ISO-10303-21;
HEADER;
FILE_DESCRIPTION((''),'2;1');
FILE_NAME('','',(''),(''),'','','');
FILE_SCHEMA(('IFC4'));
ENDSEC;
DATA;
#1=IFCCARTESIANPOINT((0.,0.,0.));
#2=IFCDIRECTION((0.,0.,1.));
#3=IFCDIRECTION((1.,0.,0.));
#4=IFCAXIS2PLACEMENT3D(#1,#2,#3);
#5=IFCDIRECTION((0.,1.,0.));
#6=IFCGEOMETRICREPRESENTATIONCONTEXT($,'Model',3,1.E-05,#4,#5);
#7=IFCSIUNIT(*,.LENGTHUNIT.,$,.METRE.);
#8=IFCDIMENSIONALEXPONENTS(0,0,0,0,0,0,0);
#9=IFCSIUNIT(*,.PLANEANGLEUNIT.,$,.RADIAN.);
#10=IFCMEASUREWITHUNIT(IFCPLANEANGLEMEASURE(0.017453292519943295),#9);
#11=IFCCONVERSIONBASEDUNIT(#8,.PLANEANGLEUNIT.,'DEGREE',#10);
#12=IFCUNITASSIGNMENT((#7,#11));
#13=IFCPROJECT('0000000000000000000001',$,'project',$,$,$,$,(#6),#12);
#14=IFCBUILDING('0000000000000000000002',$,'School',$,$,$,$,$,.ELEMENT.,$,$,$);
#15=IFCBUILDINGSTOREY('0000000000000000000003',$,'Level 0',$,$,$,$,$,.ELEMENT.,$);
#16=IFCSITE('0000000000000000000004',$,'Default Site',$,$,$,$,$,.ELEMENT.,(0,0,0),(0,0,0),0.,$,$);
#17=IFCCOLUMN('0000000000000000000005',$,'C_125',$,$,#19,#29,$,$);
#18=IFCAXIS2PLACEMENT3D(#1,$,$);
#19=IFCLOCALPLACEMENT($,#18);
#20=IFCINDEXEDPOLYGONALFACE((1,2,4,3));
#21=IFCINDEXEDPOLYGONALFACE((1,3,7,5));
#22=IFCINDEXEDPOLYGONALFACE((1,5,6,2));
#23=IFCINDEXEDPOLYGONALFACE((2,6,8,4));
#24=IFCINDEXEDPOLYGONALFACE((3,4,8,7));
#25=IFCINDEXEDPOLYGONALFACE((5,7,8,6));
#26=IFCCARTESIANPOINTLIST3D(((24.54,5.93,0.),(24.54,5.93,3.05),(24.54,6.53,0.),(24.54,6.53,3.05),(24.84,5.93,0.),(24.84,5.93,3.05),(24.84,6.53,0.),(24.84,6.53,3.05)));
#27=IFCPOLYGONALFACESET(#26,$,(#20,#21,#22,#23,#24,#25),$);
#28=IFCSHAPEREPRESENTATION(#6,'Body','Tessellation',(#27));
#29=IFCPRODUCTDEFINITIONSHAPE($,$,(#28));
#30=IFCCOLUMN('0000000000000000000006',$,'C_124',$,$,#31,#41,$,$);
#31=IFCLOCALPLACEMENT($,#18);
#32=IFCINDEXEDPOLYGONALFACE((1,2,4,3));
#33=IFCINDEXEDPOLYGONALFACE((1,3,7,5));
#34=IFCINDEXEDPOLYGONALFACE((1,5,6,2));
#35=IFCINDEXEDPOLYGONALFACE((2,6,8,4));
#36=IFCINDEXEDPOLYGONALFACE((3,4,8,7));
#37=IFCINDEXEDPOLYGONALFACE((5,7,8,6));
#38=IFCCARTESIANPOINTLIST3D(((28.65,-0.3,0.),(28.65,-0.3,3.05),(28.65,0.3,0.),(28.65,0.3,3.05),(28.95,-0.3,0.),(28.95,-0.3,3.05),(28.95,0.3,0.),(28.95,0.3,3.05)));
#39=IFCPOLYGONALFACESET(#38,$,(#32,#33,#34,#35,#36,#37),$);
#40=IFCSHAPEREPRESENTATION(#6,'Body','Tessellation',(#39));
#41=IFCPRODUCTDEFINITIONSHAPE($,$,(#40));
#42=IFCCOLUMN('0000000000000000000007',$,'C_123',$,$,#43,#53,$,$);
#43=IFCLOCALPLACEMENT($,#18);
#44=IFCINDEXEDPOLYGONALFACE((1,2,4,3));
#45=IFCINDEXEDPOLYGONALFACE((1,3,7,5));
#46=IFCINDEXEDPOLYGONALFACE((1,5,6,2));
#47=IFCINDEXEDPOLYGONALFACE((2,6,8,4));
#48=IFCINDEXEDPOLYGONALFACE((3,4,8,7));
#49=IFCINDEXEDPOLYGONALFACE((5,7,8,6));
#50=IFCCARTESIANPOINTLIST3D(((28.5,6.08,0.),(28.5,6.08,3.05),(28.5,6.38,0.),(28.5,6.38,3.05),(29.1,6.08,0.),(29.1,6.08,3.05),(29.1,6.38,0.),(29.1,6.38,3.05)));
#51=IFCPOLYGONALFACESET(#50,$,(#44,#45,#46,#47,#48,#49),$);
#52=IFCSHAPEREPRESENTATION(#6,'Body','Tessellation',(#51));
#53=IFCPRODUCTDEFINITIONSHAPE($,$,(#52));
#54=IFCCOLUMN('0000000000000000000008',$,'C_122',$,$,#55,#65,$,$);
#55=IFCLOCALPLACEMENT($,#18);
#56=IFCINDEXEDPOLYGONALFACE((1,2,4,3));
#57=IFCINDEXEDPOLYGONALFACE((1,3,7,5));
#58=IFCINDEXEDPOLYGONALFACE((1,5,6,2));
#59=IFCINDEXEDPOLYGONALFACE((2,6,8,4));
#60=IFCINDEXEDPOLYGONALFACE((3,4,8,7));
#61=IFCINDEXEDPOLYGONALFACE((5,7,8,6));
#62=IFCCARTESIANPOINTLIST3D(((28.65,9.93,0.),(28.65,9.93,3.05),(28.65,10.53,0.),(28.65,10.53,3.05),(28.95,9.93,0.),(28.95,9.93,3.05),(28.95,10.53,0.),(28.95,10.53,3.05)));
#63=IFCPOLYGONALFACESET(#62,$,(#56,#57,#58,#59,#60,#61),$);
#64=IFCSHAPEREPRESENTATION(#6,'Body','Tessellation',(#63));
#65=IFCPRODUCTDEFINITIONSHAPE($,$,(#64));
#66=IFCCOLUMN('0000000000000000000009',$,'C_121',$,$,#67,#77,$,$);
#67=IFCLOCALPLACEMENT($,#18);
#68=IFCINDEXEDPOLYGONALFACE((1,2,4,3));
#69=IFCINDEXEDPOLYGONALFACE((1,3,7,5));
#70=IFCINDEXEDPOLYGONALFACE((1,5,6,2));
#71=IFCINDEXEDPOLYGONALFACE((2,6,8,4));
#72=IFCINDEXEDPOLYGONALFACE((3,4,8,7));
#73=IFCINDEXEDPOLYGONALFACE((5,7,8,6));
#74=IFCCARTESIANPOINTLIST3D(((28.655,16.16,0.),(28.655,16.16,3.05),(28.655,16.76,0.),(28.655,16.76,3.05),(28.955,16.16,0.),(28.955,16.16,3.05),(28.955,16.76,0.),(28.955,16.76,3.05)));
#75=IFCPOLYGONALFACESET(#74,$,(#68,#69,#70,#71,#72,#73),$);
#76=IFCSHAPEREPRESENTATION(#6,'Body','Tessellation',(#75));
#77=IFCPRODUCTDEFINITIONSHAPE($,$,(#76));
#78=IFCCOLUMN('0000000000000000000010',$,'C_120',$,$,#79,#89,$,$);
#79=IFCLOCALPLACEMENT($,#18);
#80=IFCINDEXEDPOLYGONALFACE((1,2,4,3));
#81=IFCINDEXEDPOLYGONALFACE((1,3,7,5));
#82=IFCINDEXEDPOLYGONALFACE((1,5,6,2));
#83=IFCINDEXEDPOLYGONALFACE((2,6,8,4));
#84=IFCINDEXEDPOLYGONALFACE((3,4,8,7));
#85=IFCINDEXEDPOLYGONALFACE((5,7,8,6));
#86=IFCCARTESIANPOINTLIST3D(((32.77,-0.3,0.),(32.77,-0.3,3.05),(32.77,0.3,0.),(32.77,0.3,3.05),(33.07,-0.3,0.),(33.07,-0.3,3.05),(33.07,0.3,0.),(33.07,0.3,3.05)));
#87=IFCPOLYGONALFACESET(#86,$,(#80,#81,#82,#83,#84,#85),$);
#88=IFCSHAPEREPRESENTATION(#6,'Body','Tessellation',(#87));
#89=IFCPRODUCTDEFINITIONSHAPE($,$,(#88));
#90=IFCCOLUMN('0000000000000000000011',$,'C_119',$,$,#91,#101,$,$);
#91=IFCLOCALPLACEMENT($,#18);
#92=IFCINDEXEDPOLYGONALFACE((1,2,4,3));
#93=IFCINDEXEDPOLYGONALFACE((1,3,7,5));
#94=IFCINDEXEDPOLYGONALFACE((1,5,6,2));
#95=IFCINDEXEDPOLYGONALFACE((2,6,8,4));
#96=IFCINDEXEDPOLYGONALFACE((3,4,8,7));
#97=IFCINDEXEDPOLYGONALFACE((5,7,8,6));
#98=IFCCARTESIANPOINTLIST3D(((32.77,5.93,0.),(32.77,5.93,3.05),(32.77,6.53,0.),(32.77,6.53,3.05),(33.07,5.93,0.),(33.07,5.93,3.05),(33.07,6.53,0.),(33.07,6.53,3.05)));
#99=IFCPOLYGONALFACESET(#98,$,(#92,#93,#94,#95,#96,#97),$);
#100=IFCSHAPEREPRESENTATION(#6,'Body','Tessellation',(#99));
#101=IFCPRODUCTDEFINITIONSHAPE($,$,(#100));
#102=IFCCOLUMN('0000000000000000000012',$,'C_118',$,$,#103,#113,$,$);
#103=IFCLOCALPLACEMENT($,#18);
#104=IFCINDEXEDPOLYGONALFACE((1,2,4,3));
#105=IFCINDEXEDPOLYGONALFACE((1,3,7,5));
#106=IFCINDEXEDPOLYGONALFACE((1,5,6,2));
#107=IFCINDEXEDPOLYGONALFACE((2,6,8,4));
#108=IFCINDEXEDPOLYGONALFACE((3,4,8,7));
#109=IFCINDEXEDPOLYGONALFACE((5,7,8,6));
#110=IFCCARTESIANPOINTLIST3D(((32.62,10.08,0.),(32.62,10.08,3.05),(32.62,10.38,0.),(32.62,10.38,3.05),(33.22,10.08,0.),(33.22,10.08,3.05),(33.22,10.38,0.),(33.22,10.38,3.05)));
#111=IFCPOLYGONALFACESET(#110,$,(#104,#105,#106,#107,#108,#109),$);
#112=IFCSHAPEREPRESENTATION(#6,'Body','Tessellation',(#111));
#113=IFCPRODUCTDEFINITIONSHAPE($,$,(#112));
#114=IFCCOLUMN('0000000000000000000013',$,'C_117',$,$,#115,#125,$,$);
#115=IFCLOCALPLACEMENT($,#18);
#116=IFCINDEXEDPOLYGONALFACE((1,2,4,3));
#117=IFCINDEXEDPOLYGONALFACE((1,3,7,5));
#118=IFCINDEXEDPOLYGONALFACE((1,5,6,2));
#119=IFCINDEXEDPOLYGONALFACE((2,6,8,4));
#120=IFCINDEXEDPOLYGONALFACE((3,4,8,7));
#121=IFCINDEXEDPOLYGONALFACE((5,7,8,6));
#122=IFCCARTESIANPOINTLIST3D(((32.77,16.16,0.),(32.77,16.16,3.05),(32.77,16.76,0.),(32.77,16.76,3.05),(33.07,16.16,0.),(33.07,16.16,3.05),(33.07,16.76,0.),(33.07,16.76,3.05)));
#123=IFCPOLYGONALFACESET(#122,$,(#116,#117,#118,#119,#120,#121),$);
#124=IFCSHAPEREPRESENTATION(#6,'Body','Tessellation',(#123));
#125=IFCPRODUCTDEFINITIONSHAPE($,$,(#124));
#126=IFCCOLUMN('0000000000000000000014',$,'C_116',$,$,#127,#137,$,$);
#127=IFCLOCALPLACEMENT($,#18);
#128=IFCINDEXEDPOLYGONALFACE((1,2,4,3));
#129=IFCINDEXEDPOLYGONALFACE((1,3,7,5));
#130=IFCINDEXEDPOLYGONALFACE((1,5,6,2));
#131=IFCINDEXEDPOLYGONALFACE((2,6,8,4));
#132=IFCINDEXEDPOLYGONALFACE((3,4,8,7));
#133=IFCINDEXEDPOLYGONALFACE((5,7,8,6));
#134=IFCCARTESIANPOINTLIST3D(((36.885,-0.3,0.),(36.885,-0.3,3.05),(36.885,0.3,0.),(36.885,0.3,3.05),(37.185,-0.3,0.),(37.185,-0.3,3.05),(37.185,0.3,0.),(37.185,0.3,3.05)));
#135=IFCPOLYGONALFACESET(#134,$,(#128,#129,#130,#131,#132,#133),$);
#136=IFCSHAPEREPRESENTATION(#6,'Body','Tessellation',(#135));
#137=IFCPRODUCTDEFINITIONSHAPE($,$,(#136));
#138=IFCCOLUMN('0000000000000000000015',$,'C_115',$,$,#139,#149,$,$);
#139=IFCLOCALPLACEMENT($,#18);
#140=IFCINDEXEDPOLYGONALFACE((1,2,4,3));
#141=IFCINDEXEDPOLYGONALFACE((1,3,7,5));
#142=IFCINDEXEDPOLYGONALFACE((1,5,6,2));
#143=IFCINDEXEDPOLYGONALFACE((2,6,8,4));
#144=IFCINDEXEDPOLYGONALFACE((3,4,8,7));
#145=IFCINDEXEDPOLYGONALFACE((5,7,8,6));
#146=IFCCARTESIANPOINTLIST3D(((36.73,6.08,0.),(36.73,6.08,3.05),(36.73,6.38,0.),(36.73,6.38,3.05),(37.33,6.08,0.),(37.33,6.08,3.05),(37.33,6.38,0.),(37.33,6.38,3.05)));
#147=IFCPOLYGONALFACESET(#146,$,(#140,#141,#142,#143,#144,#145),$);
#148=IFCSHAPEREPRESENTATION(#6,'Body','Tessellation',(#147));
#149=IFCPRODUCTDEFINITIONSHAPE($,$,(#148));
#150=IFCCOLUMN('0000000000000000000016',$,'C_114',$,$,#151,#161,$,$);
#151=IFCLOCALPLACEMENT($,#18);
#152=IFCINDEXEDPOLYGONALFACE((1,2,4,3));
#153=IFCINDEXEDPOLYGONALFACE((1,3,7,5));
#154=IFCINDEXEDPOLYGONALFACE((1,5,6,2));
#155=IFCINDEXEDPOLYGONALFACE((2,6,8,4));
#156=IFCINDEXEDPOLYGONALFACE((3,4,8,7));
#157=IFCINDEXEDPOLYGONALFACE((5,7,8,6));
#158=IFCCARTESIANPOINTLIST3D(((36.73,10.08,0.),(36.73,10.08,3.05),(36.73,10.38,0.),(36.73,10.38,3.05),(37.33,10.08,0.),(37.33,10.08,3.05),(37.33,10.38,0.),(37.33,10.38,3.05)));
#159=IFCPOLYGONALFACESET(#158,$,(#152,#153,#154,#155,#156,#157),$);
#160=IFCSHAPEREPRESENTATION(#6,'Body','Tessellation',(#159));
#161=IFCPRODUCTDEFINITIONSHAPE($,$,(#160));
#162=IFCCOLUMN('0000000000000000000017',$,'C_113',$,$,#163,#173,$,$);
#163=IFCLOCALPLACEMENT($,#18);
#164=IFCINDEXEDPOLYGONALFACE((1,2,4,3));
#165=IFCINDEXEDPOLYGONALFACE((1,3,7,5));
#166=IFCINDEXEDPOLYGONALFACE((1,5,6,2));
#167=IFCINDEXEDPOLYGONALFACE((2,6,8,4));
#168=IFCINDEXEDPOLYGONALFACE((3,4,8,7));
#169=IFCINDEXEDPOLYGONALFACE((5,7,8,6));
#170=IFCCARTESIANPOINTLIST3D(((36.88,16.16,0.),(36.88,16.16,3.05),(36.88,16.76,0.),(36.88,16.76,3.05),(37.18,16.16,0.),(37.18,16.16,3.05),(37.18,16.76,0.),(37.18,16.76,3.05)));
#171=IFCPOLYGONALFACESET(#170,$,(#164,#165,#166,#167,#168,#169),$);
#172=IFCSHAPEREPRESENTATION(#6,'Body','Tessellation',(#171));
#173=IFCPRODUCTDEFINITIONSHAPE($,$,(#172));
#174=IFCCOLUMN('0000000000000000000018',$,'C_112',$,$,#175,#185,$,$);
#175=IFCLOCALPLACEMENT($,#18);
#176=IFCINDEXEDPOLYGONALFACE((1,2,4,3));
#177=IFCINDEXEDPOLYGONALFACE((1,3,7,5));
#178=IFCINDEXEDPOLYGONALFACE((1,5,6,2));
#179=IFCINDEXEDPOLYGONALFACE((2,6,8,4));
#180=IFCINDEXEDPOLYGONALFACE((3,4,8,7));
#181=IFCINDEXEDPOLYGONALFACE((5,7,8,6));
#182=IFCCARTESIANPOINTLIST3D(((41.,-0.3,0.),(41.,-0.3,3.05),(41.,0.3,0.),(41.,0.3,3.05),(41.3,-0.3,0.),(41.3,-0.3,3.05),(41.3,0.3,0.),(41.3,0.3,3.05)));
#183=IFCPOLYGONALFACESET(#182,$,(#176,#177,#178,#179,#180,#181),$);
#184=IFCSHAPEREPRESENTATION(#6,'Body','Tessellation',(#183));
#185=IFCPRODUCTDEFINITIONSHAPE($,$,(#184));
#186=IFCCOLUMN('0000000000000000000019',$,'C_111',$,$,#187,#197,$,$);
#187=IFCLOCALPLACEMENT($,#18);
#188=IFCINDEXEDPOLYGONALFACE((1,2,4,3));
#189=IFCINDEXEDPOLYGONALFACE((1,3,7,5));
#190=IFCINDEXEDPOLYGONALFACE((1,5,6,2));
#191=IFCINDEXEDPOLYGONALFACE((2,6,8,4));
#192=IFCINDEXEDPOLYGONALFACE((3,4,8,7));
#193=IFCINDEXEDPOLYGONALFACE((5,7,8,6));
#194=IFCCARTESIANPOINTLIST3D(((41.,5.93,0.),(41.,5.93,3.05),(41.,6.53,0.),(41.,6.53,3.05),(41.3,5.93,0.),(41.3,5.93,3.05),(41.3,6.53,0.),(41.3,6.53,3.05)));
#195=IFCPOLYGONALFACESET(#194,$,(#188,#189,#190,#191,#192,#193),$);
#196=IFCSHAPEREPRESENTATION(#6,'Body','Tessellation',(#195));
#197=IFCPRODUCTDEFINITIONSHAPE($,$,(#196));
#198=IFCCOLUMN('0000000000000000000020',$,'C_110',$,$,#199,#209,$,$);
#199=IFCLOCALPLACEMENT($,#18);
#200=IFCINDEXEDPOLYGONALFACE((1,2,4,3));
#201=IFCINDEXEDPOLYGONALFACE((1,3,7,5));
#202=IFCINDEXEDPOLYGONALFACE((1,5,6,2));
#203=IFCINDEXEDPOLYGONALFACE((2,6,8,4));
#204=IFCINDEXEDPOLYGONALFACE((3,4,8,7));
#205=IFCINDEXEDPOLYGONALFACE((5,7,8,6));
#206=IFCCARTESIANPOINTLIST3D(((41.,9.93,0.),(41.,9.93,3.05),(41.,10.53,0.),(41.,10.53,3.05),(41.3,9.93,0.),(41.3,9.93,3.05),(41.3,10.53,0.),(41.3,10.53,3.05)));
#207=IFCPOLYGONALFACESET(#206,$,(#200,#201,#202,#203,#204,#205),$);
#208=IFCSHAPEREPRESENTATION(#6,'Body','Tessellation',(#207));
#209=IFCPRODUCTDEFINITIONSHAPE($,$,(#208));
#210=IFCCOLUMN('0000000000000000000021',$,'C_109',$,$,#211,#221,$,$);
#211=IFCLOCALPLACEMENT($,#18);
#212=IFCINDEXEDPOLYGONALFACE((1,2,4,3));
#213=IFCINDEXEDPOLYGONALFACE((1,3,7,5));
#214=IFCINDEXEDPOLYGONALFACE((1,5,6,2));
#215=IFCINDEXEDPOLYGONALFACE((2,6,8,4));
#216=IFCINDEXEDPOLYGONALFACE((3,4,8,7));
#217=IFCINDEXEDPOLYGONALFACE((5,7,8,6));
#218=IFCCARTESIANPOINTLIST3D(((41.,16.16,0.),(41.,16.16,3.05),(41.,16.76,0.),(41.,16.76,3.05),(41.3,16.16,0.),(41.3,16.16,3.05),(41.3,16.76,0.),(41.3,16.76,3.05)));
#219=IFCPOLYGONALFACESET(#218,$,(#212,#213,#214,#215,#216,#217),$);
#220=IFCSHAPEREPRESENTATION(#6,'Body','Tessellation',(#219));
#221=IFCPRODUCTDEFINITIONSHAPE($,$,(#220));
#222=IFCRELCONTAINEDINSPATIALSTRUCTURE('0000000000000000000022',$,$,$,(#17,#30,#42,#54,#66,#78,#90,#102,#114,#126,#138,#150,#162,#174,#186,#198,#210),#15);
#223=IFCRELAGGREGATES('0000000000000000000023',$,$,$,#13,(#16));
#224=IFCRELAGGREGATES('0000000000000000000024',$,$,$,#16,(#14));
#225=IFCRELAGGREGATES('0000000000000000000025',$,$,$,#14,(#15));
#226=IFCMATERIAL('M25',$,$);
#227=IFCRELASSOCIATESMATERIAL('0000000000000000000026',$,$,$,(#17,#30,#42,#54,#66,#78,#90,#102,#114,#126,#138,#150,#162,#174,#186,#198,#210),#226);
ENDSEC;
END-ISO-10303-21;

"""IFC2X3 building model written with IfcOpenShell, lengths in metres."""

from ifc_helpers import new_model, entity, si_unit, converted_unit, direction, frame, frame_2d, origin_with_axes, place, context, project, spatial, rectangle, extrude, material, element, save


model = new_model("IFC2X3")

# Units and contexts
model_context = context("Model", 3, precision=1e-05, world=origin_with_axes(), true_north=direction((0.0, 1.0, 0.0)))
ifc_project = project(units=[si_unit("LENGTHUNIT", "METRE"), converted_unit("PLANEANGLEUNIT", "DEGREE", entity("IfcPlaneAngleMeasure", 0.017453292519943295), si_unit("PLANEANGLEUNIT", "RADIAN"), dimensions=[0, 0, 0, 0, 0, 0, 0])], contexts=[model_context])

# Site, building, storey
site = spatial("IfcSite", under=ifc_project, Name="Default Site", CompositionType="ELEMENT", RefLatitude=(0, 0, 0), RefLongitude=(0, 0, 0), RefElevation=0.0)
building = spatial("IfcBuilding", under=site, Name="School", CompositionType="ELEMENT")
storey = spatial("IfcBuildingStorey", under=building, Name="Level 0", CompositionType="ELEMENT")

# Columns
ifc_material = material(Name="M25")
placement = place(None, origin_with_axes())
element("IfcColumn", 1, at=placement, inside=storey, material=ifc_material, Name="C_125", context=model_context, shape_type="SweptSolid", body=[
    extrude(rectangle(XDim=0.3, YDim=0.6, at=frame_2d((0.0, 0.0), x_axis=(1.0, 0.0, 0.0))), frame((24.69, 6.23, 0.0), z_axis=(0.0, 0.0, 1.0), x_axis=(1.0, 0.0, 0.0)), (0.0, 0.0, 1.0), 3.05),
])
element("IfcColumn", 2, at=placement, inside=storey, material=ifc_material, Name="C_124", context=model_context, shape_type="SweptSolid", body=[
    extrude(rectangle(XDim=0.3, YDim=0.6, at=frame_2d((0.0, 0.0), x_axis=(1.0, 0.0, 0.0))), frame((28.8, 0.0, 0.0), z_axis=(0.0, 0.0, 1.0), x_axis=(1.0, 0.0, 0.0)), (0.0, 0.0, 1.0), 3.05),
])
element("IfcColumn", 3, at=placement, inside=storey, material=ifc_material, Name="C_123", context=model_context, shape_type="SweptSolid", body=[
    extrude(rectangle(XDim=0.6, YDim=0.3, at=frame_2d((0.0, 0.0), x_axis=(1.0, 0.0, 0.0))), frame((28.8, 6.23, 0.0), z_axis=(0.0, 0.0, 1.0), x_axis=(1.0, 0.0, 0.0)), (0.0, 0.0, 1.0), 3.05),
])
element("IfcColumn", 4, at=placement, inside=storey, material=ifc_material, Name="C_122", context=model_context, shape_type="SweptSolid", body=[
    extrude(rectangle(XDim=0.3, YDim=0.6, at=frame_2d((0.0, 0.0), x_axis=(1.0, 0.0, 0.0))), frame((28.8, 10.23, 0.0), z_axis=(0.0, 0.0, 1.0), x_axis=(1.0, 0.0, 0.0)), (0.0, 0.0, 1.0), 3.05),
])
element("IfcColumn", 5, at=placement, inside=storey, material=ifc_material, Name="C_121", context=model_context, shape_type="SweptSolid", body=[
    extrude(rectangle(XDim=0.3, YDim=0.6, at=frame_2d((0.0, 0.0), x_axis=(1.0, 0.0, 0.0))), frame((28.805, 16.46, 0.0), z_axis=(0.0, 0.0, 1.0), x_axis=(1.0, 0.0, 0.0)), (0.0, 0.0, 1.0), 3.05),
])
element("IfcColumn", 6, at=placement, inside=storey, material=ifc_material, Name="C_120", context=model_context, shape_type="SweptSolid", body=[
    extrude(rectangle(XDim=0.3, YDim=0.6, at=frame_2d((0.0, 0.0), x_axis=(1.0, 0.0, 0.0))), frame((32.92, 0.0, 0.0), z_axis=(0.0, 0.0, 1.0), x_axis=(1.0, 0.0, 0.0)), (0.0, 0.0, 1.0), 3.05),
])
element("IfcColumn", 7, at=placement, inside=storey, material=ifc_material, Name="C_119", context=model_context, shape_type="SweptSolid", body=[
    extrude(rectangle(XDim=0.3, YDim=0.6, at=frame_2d((0.0, 0.0), x_axis=(1.0, 0.0, 0.0))), frame((32.92, 6.23, 0.0), z_axis=(0.0, 0.0, 1.0), x_axis=(1.0, 0.0, 0.0)), (0.0, 0.0, 1.0), 3.05),
])
element("IfcColumn", 8, at=placement, inside=storey, material=ifc_material, Name="C_118", context=model_context, shape_type="SweptSolid", body=[
    extrude(rectangle(XDim=0.6, YDim=0.3, at=frame_2d((0.0, 0.0), x_axis=(1.0, 0.0, 0.0))), frame((32.92, 10.23, 0.0), z_axis=(0.0, 0.0, 1.0), x_axis=(1.0, 0.0, 0.0)), (0.0, 0.0, 1.0), 3.05),
])
element("IfcColumn", 9, at=placement, inside=storey, material=ifc_material, Name="C_117", context=model_context, shape_type="SweptSolid", body=[
    extrude(rectangle(XDim=0.3, YDim=0.6, at=frame_2d((0.0, 0.0), x_axis=(1.0, 0.0, 0.0))), frame((32.92, 16.46, 0.0), z_axis=(0.0, 0.0, 1.0), x_axis=(1.0, 0.0, 0.0)), (0.0, 0.0, 1.0), 3.05),
])
element("IfcColumn", 10, at=placement, inside=storey, material=ifc_material, Name="C_116", context=model_context, shape_type="SweptSolid", body=[
    extrude(rectangle(XDim=0.3, YDim=0.6, at=frame_2d((0.0, 0.0), x_axis=(1.0, 0.0, 0.0))), frame((37.035, 0.0, 0.0), z_axis=(0.0, 0.0, 1.0), x_axis=(1.0, 0.0, 0.0)), (0.0, 0.0, 1.0), 3.05),
])
element("IfcColumn", 11, at=placement, inside=storey, material=ifc_material, Name="C_115", context=model_context, shape_type="SweptSolid", body=[
    extrude(rectangle(XDim=0.6, YDim=0.3, at=frame_2d((0.0, 0.0), x_axis=(1.0, 0.0, 0.0))), frame((37.03, 6.23, 0.0), z_axis=(0.0, 0.0, 1.0), x_axis=(1.0, 0.0, 0.0)), (0.0, 0.0, 1.0), 3.05),
])
element("IfcColumn", 12, at=placement, inside=storey, material=ifc_material, Name="C_114", context=model_context, shape_type="SweptSolid", body=[
    extrude(rectangle(XDim=0.6, YDim=0.3, at=frame_2d((0.0, 0.0), x_axis=(1.0, 0.0, 0.0))), frame((37.03, 10.23, 0.0), z_axis=(0.0, 0.0, 1.0), x_axis=(1.0, 0.0, 0.0)), (0.0, 0.0, 1.0), 3.05),
])
element("IfcColumn", 13, at=placement, inside=storey, material=ifc_material, Name="C_113", context=model_context, shape_type="SweptSolid", body=[
    extrude(rectangle(XDim=0.3, YDim=0.6, at=frame_2d((0.0, 0.0), x_axis=(1.0, 0.0, 0.0))), frame((37.03, 16.46, 0.0), z_axis=(0.0, 0.0, 1.0), x_axis=(1.0, 0.0, 0.0)), (0.0, 0.0, 1.0), 3.05),
])
element("IfcColumn", 14, at=placement, inside=storey, material=ifc_material, Name="C_112", context=model_context, shape_type="SweptSolid", body=[
    extrude(rectangle(XDim=0.3, YDim=0.6, at=frame_2d((0.0, 0.0), x_axis=(1.0, 0.0, 0.0))), frame((41.15, 0.0, 0.0), z_axis=(0.0, 0.0, 1.0), x_axis=(1.0, 0.0, 0.0)), (0.0, 0.0, 1.0), 3.05),
])
element("IfcColumn", 15, at=placement, inside=storey, material=ifc_material, Name="C_111", context=model_context, shape_type="SweptSolid", body=[
    extrude(rectangle(XDim=0.3, YDim=0.6, at=frame_2d((0.0, 0.0), x_axis=(1.0, 0.0, 0.0))), frame((41.15, 6.23, 0.0), z_axis=(0.0, 0.0, 1.0), x_axis=(1.0, 0.0, 0.0)), (0.0, 0.0, 1.0), 3.05),
])
element("IfcColumn", 16, at=placement, inside=storey, material=ifc_material, Name="C_110", context=model_context, shape_type="SweptSolid", body=[
    extrude(rectangle(XDim=0.3, YDim=0.6, at=frame_2d((0.0, 0.0), x_axis=(1.0, 0.0, 0.0))), frame((41.15, 10.23, 0.0), z_axis=(0.0, 0.0, 1.0), x_axis=(1.0, 0.0, 0.0)), (0.0, 0.0, 1.0), 3.05),
])
element("IfcColumn", 17, at=placement, inside=storey, material=ifc_material, Name="C_109", context=model_context, shape_type="SweptSolid", body=[
    extrude(rectangle(XDim=0.3, YDim=0.6, at=frame_2d((0.0, 0.0), x_axis=(1.0, 0.0, 0.0))), frame((41.15, 16.46, 0.0), z_axis=(0.0, 0.0, 1.0), x_axis=(1.0, 0.0, 0.0)), (0.0, 0.0, 1.0), 3.05),
])

save(model, "model.ifc")
